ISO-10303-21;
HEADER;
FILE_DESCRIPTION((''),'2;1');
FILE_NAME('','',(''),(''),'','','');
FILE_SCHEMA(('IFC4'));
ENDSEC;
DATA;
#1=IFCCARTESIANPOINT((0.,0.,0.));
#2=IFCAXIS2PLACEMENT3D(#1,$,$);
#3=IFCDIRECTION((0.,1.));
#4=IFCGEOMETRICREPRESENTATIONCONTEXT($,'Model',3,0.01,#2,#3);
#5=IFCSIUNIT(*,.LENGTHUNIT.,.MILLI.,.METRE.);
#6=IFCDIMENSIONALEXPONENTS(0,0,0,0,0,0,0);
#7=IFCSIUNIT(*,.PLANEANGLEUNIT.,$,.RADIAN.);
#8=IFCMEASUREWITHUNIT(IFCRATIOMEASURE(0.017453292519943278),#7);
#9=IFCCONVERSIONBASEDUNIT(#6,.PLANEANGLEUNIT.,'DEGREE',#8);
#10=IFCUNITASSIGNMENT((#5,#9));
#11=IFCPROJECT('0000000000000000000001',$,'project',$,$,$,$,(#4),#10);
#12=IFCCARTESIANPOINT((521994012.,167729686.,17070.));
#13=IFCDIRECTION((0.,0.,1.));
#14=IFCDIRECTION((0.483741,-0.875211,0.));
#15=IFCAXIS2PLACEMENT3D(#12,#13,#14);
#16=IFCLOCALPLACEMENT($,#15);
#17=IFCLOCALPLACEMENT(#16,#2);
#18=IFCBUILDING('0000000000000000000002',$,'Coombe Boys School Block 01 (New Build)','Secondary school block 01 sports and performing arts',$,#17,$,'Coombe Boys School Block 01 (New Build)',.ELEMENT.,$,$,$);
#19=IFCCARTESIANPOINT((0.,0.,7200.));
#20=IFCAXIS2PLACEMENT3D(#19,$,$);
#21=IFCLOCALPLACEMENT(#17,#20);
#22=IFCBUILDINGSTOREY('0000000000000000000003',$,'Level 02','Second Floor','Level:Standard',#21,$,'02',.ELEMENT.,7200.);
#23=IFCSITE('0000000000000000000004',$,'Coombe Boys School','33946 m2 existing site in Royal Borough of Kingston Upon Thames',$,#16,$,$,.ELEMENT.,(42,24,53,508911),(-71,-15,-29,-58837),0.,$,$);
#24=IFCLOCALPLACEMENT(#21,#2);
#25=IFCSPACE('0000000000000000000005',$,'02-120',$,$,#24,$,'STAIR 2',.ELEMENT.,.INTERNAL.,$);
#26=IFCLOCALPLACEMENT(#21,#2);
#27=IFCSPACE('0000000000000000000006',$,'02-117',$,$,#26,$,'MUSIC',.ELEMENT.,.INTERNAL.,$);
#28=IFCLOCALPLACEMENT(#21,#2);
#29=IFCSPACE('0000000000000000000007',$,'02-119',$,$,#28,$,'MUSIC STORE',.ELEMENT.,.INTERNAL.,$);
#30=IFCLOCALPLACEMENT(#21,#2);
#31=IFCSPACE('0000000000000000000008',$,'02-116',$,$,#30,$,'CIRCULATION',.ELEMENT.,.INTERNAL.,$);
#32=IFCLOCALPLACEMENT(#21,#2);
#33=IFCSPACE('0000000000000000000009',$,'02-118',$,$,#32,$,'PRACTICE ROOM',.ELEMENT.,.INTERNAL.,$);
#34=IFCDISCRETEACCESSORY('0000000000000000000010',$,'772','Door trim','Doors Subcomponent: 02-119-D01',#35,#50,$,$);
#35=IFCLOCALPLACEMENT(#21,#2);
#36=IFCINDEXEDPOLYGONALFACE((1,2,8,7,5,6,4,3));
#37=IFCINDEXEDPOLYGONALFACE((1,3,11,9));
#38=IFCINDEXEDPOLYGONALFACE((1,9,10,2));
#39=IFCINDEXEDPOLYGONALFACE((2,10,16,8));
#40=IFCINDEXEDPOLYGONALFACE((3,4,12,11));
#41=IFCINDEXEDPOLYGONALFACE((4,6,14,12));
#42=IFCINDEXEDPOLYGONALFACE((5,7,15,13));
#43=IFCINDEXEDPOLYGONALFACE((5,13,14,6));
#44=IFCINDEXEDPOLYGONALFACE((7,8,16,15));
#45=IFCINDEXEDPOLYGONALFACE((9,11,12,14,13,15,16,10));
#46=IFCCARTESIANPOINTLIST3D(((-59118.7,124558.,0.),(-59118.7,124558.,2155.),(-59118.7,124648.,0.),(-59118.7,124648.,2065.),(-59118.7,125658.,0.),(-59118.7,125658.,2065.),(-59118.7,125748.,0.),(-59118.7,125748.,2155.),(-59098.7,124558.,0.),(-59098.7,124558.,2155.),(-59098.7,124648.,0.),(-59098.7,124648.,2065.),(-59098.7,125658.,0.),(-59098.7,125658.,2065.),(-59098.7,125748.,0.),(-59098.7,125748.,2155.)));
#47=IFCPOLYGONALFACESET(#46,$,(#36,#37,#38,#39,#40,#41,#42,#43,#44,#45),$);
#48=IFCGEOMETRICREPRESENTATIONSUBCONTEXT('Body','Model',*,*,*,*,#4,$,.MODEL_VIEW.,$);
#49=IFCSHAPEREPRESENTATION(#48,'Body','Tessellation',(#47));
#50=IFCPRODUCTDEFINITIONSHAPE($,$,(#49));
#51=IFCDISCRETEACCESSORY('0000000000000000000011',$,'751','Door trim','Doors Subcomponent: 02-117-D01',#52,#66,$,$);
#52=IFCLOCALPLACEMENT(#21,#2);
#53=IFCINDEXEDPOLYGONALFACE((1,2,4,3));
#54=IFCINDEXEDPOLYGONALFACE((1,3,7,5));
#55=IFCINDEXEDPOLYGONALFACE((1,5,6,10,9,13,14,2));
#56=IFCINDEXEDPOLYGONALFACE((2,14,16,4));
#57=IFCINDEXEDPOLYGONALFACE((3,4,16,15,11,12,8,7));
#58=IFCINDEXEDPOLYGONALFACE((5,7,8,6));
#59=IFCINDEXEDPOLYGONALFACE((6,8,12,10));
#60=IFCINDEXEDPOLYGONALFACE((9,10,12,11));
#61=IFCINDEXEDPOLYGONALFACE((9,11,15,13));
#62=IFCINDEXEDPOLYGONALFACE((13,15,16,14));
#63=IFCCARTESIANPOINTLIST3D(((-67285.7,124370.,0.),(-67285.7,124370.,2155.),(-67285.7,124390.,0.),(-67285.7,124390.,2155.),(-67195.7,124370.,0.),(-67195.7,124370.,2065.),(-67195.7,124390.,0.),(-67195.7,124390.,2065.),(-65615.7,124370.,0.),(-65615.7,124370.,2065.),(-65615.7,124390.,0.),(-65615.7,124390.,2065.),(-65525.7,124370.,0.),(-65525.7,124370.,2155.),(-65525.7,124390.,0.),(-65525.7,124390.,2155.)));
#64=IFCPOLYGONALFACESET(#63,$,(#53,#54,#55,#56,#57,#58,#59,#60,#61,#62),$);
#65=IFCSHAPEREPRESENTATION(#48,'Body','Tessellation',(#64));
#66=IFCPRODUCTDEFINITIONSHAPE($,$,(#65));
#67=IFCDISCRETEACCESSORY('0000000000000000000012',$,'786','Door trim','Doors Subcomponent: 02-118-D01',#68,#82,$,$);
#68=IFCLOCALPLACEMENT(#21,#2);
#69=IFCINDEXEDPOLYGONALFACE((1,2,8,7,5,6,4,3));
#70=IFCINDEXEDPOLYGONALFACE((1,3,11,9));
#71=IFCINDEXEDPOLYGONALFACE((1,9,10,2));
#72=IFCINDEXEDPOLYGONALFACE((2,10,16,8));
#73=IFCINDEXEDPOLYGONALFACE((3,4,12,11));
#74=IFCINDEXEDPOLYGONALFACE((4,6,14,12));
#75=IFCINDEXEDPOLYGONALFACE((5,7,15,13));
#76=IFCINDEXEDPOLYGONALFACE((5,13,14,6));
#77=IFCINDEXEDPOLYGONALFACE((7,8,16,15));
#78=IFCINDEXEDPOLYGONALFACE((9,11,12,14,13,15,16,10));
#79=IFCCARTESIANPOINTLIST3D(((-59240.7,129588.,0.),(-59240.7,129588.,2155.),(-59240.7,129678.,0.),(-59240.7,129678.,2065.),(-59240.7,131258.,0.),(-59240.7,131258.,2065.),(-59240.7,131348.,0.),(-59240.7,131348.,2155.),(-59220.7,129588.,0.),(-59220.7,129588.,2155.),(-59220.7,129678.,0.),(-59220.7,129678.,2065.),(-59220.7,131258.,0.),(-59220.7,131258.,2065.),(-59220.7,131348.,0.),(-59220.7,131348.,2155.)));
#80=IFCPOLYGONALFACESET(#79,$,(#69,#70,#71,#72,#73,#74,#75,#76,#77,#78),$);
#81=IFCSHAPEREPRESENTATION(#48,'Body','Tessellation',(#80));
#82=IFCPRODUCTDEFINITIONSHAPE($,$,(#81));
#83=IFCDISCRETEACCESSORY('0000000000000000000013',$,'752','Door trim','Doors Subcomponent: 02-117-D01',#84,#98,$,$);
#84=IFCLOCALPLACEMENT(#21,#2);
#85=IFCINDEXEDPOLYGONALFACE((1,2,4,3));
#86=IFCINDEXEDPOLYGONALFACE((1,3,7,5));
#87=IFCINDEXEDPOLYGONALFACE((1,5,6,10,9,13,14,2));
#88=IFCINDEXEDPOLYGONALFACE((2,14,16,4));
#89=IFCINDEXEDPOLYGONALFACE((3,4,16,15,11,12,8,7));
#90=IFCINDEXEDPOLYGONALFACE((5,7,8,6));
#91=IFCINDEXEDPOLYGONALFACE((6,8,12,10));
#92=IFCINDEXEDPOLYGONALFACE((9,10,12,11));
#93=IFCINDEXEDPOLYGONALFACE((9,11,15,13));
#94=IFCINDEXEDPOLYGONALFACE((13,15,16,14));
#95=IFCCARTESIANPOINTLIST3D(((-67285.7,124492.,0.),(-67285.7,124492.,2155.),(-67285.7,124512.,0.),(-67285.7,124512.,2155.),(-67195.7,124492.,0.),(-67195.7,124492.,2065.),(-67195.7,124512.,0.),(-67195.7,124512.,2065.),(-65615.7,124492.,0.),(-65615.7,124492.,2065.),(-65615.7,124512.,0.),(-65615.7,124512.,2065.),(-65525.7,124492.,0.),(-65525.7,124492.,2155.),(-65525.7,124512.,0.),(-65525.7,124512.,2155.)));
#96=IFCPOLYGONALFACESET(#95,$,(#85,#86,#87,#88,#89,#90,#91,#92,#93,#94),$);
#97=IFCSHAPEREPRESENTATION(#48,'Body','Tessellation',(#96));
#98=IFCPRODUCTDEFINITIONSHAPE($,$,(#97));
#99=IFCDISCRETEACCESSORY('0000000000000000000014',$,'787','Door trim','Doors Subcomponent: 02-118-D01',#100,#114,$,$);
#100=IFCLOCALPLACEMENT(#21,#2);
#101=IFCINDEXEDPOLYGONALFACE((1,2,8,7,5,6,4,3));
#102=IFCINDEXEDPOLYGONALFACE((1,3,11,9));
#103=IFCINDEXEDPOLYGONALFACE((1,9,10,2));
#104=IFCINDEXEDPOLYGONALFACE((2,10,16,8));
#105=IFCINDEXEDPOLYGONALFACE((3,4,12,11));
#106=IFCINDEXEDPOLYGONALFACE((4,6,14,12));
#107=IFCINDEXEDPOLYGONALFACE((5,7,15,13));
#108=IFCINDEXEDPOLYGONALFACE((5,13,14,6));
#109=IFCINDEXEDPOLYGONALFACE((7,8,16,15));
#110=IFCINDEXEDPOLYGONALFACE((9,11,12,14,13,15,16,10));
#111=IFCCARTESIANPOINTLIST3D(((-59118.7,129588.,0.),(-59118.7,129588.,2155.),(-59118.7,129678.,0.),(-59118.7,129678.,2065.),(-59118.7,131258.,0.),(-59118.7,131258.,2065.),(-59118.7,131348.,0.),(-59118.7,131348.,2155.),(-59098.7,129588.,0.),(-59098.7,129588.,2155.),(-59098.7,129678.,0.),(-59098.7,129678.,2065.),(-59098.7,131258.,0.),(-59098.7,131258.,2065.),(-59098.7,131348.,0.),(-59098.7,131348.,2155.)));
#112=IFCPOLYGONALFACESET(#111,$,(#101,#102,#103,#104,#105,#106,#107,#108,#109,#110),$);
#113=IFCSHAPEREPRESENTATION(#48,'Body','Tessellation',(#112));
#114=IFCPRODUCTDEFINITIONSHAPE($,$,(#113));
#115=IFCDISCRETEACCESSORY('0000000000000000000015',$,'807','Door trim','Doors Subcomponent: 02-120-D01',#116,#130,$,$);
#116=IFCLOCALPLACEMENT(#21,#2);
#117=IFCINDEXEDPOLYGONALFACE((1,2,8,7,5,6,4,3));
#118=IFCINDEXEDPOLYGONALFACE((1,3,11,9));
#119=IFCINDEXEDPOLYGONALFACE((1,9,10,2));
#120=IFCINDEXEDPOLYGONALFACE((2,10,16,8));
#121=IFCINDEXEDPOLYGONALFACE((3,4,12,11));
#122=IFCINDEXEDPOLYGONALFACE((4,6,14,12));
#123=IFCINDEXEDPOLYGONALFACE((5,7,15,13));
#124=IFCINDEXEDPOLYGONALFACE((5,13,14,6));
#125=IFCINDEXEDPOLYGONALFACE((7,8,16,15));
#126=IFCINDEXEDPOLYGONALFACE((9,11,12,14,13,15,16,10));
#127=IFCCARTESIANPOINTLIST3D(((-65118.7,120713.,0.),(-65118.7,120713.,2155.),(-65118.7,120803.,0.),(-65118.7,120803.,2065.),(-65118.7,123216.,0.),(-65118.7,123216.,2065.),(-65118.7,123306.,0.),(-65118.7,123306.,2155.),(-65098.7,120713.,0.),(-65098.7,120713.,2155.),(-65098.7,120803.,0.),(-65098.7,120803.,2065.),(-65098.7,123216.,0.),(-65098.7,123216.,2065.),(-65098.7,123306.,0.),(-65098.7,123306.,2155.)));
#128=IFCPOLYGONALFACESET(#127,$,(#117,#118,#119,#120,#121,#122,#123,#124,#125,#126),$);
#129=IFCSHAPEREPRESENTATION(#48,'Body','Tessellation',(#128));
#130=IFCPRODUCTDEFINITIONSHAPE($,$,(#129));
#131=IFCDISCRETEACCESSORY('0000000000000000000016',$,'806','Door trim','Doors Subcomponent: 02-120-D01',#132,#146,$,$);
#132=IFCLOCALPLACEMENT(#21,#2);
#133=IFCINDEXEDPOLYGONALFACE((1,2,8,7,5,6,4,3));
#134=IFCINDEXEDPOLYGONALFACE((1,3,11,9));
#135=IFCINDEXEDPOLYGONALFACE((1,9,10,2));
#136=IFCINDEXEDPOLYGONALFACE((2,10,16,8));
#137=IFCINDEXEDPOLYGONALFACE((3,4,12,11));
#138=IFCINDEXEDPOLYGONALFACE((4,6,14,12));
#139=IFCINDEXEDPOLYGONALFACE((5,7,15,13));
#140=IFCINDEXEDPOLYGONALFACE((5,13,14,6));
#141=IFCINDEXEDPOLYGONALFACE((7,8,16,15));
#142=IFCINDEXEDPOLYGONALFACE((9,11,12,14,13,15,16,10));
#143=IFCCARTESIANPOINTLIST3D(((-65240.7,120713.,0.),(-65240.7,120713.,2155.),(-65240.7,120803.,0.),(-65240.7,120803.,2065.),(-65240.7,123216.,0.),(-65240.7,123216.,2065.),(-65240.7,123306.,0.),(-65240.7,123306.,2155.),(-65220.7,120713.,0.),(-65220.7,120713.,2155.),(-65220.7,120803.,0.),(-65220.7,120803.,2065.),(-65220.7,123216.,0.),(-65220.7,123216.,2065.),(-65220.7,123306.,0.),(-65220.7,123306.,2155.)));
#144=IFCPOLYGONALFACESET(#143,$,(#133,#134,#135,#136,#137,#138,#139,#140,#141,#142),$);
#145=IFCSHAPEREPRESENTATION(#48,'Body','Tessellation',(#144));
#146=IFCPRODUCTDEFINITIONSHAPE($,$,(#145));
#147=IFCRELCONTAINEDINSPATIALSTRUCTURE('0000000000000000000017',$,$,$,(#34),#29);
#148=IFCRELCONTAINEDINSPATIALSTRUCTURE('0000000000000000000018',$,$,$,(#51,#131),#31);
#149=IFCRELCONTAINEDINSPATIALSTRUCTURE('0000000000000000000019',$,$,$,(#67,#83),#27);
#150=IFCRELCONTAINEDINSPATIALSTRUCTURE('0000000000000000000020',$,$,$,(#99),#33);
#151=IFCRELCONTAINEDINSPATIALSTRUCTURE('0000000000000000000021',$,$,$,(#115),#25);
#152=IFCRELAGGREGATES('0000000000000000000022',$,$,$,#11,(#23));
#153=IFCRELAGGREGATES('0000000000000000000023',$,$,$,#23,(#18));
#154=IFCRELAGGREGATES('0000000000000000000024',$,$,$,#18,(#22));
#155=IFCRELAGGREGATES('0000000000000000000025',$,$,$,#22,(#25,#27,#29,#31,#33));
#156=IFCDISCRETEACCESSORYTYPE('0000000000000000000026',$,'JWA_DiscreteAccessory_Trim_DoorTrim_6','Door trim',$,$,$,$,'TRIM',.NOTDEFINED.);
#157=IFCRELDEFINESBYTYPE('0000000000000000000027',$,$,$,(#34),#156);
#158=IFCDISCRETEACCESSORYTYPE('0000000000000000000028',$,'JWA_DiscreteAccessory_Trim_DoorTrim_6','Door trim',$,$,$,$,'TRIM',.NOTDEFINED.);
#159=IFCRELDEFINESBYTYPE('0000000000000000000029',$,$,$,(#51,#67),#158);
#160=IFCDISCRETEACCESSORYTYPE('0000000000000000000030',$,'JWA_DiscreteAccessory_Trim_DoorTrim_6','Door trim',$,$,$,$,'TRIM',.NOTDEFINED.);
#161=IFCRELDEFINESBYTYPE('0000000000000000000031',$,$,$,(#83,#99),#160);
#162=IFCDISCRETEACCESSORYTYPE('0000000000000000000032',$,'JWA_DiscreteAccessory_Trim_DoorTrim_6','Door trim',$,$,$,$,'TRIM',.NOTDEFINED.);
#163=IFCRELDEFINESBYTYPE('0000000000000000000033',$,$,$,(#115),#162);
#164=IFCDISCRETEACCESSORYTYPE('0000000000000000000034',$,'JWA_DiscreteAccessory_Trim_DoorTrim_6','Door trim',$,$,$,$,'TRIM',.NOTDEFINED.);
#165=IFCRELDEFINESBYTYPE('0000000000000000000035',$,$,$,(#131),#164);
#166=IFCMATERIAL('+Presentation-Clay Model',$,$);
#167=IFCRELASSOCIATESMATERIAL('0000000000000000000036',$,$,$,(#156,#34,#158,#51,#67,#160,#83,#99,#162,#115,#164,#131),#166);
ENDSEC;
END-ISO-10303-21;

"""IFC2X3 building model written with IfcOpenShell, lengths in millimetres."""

from ifc_helpers import new_model, entity, si_unit, converted_unit, direction, frame, origin, place, context, subcontext, project, spatial, polyline, outline, extrude, source, transform, mapped, material, type_object, type_shapes, element, save


model = new_model("IFC2X3")

# Units and contexts
model_context = context("Model", 3, precision=0.01, world=origin(), true_north=direction((0.0, 1.0)))
body_context = subcontext(model_context, "Body", "Model", "MODEL_VIEW")
ifc_project = project(units=[si_unit("LENGTHUNIT", "METRE", prefix="MILLI"), converted_unit("PLANEANGLEUNIT", "DEGREE", entity("IfcRatioMeasure", 0.017453292519943278), si_unit("PLANEANGLEUNIT", "RADIAN"), dimensions=[0, 0, 0, 0, 0, 0, 0])], contexts=[model_context])

# Site, building, storey
site_placement = place(None, frame((521994012.0, 167729686.0, 17070.0), z_axis=(0.0, 0.0, 1.0), x_axis=(0.483741, -0.875211, 0.0)))
site = spatial("IfcSite", under=ifc_project, at=site_placement, Name="Coombe Boys School", Description="33946 m2 existing site in Royal Borough of Kingston Upon Thames", CompositionType="ELEMENT", RefLatitude=(42, 24, 53, 508911), RefLongitude=(-71, -15, -29, -58837), RefElevation=0.0)
building_placement = place(site_placement, origin())
building = spatial("IfcBuilding", under=site, at=building_placement, Name="Coombe Boys School Block 01 (New Build)", Description="Secondary school block 01 sports and performing arts", LongName="Coombe Boys School Block 01 (New Build)", CompositionType="ELEMENT")
storey_placement = place(building_placement, frame((0.0, 0.0, 7200.0)))
storey = spatial("IfcBuildingStorey", under=building, at=storey_placement, Name="Level 02", Description="Second Floor", ObjectType="Level:Standard", LongName="02", CompositionType="ELEMENT", Elevation=7200.0)

# Shared definitions
space_1_placement = place(storey_placement, origin())
space_1 = spatial("IfcSpace", under=storey, at=space_1_placement, Name="02-120", LongName="STAIR 2", CompositionType="ELEMENT", InteriorOrExteriorSpace="INTERNAL")

# Shared definitions
ifc_material_1 = material(Name="+Presentation-Clay Model")

# Shared definitions
space_2_placement = place(storey_placement, origin())
space_2 = spatial("IfcSpace", under=storey, at=space_2_placement, Name="02-117", LongName="MUSIC", CompositionType="ELEMENT", InteriorOrExteriorSpace="INTERNAL")

# Shared definitions
space_3_placement = place(storey_placement, origin())
space_3 = spatial("IfcSpace", under=storey, at=space_3_placement, Name="02-119", LongName="MUSIC STORE", CompositionType="ELEMENT", InteriorOrExteriorSpace="INTERNAL")

# Discrete accessory
discrete_accessory_type_1 = type_object("IfcDiscreteAccessoryType", Name="JWA_DiscreteAccessory_Trim_DoorTrim_6", Description="Door trim", ElementType="TRIM", material=ifc_material_1)
shared_shape_1 = source(origin(), body_context, "Body", "SweptSolid", [
    extrude(outline(polyline([(505.0, -1055.0), (595.0, -1055.0), (595.0, 1100.0), (-595.0, 1100.0), (-595.0, -1055.0), (-505.0, -1055.0), (-505.0, 1010.0), (505.0, 1010.0), (505.0, -1055.0)])), frame((0.0, 0.0, 1055.0), z_axis=(0.0, 1.0, 0.0), x_axis=(-1.0, 0.0, 0.0)), (0.0, 0.0, 1.0), 20.0),
])
type_shapes(discrete_accessory_type_1, [shared_shape_1])
discrete_accessory_1_placement = place(space_3_placement, frame((-59118.7, 125153.0, 0.0), z_axis=(0.0, 0.0, 1.0), x_axis=(0.0, -1.0, 0.0)))
element("IfcDiscreteAccessory", 1, at=discrete_accessory_1_placement, inside=space_3, type_object=discrete_accessory_type_1, material=ifc_material_1, Name="772", Description="Door trim", ObjectType="Doors Subcomponent: 02-119-D01", context=body_context, shape_type="MappedRepresentation", body=[
    mapped(shared_shape_1, transform((0.0, 0.0, 0.0), scale=1.0)),
])

# Shared definitions
space_4_placement = place(storey_placement, origin())
space_4 = spatial("IfcSpace", under=storey, at=space_4_placement, Name="02-116", LongName="CIRCULATION", CompositionType="ELEMENT", InteriorOrExteriorSpace="INTERNAL")

# Discrete accessories
discrete_accessory_type_2 = type_object("IfcDiscreteAccessoryType", Name="JWA_DiscreteAccessory_Trim_DoorTrim_6", Description="Door trim", ElementType="TRIM", material=ifc_material_1)
shared_shape_2 = source(origin(), body_context, "Body", "SweptSolid", [
    extrude(outline(polyline([(790.0, -1055.0), (880.0, -1055.0), (880.0, 1100.0), (-880.0, 1100.0), (-880.0, -1055.0), (-790.0, -1055.0), (-790.0, 1010.0), (790.0, 1010.0), (790.0, -1055.0)])), frame((0.0, 0.0, 1055.0), z_axis=(0.0, 1.0, 0.0), x_axis=(-1.0, 0.0, 0.0)), (0.0, 0.0, 1.0), 20.0),
])
type_shapes(discrete_accessory_type_2, [shared_shape_2])
discrete_accessory_2_placement = place(space_4_placement, frame((-66405.7, 124390.0, 0.0), z_axis=(0.0, 0.0, 1.0), x_axis=(-1.0, 0.0, 0.0)))
element("IfcDiscreteAccessory", 2, at=discrete_accessory_2_placement, inside=space_4, type_object=discrete_accessory_type_2, material=ifc_material_1, Name="751", Description="Door trim", ObjectType="Doors Subcomponent: 02-117-D01", context=body_context, shape_type="MappedRepresentation", body=[
    mapped(shared_shape_2, transform((0.0, 0.0, 0.0), scale=1.0)),
])
discrete_accessory_3_placement = place(space_2_placement, frame((-59220.7, 130468.0, 0.0), z_axis=(0.0, 0.0, 1.0), x_axis=(0.0, 1.0, 0.0)))
element("IfcDiscreteAccessory", 3, at=discrete_accessory_3_placement, inside=space_2, type_object=discrete_accessory_type_2, material=ifc_material_1, Name="786", Description="Door trim", ObjectType="Doors Subcomponent: 02-118-D01", context=body_context, shape_type="MappedRepresentation", body=[
    mapped(shared_shape_2, transform((0.0, 0.0, 0.0), scale=1.0)),
])
discrete_accessory_type_3 = type_object("IfcDiscreteAccessoryType", Name="JWA_DiscreteAccessory_Trim_DoorTrim_6", Description="Door trim", ElementType="TRIM", material=ifc_material_1)
shared_shape_3 = source(origin(), body_context, "Body", "SweptSolid", [
    extrude(outline(polyline([(-1055.0, -880.0), (1100.0, -880.0), (1100.0, 880.0), (-1055.0, 880.0), (-1055.0, 790.0), (1010.0, 790.0), (1010.0, -790.0), (-1055.0, -790.0), (-1055.0, -880.0)])), frame((0.0, -20.0, 1055.0), z_axis=(0.0, 1.0, 0.0), x_axis=(0.0, 0.0, 1.0)), (0.0, 0.0, 1.0), 20.0),
])
type_shapes(discrete_accessory_type_3, [shared_shape_3])
discrete_accessory_4_placement = place(space_2_placement, frame((-66405.7, 124492.0, 0.0), z_axis=(0.0, 0.0, 1.0), x_axis=(-1.0, 0.0, 0.0)))
element("IfcDiscreteAccessory", 4, at=discrete_accessory_4_placement, inside=space_2, type_object=discrete_accessory_type_3, material=ifc_material_1, Name="752", Description="Door trim", ObjectType="Doors Subcomponent: 02-117-D01", context=body_context, shape_type="MappedRepresentation", body=[
    mapped(shared_shape_3, transform((0.0, 0.0, 0.0), scale=1.0)),
])

# Shared definitions
space_5_placement = place(storey_placement, origin())
space_5 = spatial("IfcSpace", under=storey, at=space_5_placement, Name="02-118", LongName="PRACTICE ROOM", CompositionType="ELEMENT", InteriorOrExteriorSpace="INTERNAL")

# Discrete accessories
discrete_accessory_5_placement = place(space_5_placement, frame((-59118.7, 130468.0, 0.0), z_axis=(0.0, 0.0, 1.0), x_axis=(0.0, 1.0, 0.0)))
element("IfcDiscreteAccessory", 5, at=discrete_accessory_5_placement, inside=space_5, type_object=discrete_accessory_type_3, material=ifc_material_1, Name="787", Description="Door trim", ObjectType="Doors Subcomponent: 02-118-D01", context=body_context, shape_type="MappedRepresentation", body=[
    mapped(shared_shape_3, transform((0.0, 0.0, 0.0), scale=1.0)),
])
discrete_accessory_type_4 = type_object("IfcDiscreteAccessoryType", Name="JWA_DiscreteAccessory_Trim_DoorTrim_6", Description="Door trim", ElementType="TRIM", material=ifc_material_1)
shared_shape_4 = source(origin(), body_context, "Body", "SweptSolid", [
    extrude(outline(polyline([(1206.5, -1055.0), (1296.5, -1055.0), (1296.5, 1100.0), (-1296.5, 1100.0), (-1296.5, -1055.0), (-1206.5, -1055.0), (-1206.5, 1010.0), (1206.5, 1010.0), (1206.5, -1055.0)])), frame((0.0, 0.0, 1055.0), z_axis=(0.0, 1.0, 0.0), x_axis=(-1.0, 0.0, 0.0)), (0.0, 0.0, 1.0), 20.0),
])
type_shapes(discrete_accessory_type_4, [shared_shape_4])
discrete_accessory_6_placement = place(space_1_placement, frame((-65118.7, 122009.5, 0.0), z_axis=(0.0, 0.0, 1.0), x_axis=(0.0, -1.0, 0.0)))
element("IfcDiscreteAccessory", 6, at=discrete_accessory_6_placement, inside=space_1, type_object=discrete_accessory_type_4, material=ifc_material_1, Name="807", Description="Door trim", ObjectType="Doors Subcomponent: 02-120-D01", context=body_context, shape_type="MappedRepresentation", body=[
    mapped(shared_shape_4, transform((0.0, 0.0, 0.0), scale=1.0)),
])
discrete_accessory_type_5 = type_object("IfcDiscreteAccessoryType", Name="JWA_DiscreteAccessory_Trim_DoorTrim_6", Description="Door trim", ElementType="TRIM", material=ifc_material_1)
shared_shape_5 = source(origin(), body_context, "Body", "SweptSolid", [
    extrude(outline(polyline([(-1055.0, -1296.5), (1100.0, -1296.5), (1100.0, 1296.5), (-1055.0, 1296.5), (-1055.0, 1206.5), (1010.0, 1206.5), (1010.0, -1206.5), (-1055.0, -1206.5), (-1055.0, -1296.5)])), frame((0.0, -20.0, 1055.0), z_axis=(0.0, 1.0, 0.0), x_axis=(0.0, 0.0, 1.0)), (0.0, 0.0, 1.0), 20.0),
])
type_shapes(discrete_accessory_type_5, [shared_shape_5])
discrete_accessory_7_placement = place(space_4_placement, frame((-65220.7, 122009.5, 0.0), z_axis=(0.0, 0.0, 1.0), x_axis=(0.0, -1.0, 0.0)))
element("IfcDiscreteAccessory", 7, at=discrete_accessory_7_placement, inside=space_4, type_object=discrete_accessory_type_5, material=ifc_material_1, Name="806", Description="Door trim", ObjectType="Doors Subcomponent: 02-120-D01", context=body_context, shape_type="MappedRepresentation", body=[
    mapped(shared_shape_5, transform((0.0, 0.0, 0.0), scale=1.0)),
])

save(model, "model.ifc")
